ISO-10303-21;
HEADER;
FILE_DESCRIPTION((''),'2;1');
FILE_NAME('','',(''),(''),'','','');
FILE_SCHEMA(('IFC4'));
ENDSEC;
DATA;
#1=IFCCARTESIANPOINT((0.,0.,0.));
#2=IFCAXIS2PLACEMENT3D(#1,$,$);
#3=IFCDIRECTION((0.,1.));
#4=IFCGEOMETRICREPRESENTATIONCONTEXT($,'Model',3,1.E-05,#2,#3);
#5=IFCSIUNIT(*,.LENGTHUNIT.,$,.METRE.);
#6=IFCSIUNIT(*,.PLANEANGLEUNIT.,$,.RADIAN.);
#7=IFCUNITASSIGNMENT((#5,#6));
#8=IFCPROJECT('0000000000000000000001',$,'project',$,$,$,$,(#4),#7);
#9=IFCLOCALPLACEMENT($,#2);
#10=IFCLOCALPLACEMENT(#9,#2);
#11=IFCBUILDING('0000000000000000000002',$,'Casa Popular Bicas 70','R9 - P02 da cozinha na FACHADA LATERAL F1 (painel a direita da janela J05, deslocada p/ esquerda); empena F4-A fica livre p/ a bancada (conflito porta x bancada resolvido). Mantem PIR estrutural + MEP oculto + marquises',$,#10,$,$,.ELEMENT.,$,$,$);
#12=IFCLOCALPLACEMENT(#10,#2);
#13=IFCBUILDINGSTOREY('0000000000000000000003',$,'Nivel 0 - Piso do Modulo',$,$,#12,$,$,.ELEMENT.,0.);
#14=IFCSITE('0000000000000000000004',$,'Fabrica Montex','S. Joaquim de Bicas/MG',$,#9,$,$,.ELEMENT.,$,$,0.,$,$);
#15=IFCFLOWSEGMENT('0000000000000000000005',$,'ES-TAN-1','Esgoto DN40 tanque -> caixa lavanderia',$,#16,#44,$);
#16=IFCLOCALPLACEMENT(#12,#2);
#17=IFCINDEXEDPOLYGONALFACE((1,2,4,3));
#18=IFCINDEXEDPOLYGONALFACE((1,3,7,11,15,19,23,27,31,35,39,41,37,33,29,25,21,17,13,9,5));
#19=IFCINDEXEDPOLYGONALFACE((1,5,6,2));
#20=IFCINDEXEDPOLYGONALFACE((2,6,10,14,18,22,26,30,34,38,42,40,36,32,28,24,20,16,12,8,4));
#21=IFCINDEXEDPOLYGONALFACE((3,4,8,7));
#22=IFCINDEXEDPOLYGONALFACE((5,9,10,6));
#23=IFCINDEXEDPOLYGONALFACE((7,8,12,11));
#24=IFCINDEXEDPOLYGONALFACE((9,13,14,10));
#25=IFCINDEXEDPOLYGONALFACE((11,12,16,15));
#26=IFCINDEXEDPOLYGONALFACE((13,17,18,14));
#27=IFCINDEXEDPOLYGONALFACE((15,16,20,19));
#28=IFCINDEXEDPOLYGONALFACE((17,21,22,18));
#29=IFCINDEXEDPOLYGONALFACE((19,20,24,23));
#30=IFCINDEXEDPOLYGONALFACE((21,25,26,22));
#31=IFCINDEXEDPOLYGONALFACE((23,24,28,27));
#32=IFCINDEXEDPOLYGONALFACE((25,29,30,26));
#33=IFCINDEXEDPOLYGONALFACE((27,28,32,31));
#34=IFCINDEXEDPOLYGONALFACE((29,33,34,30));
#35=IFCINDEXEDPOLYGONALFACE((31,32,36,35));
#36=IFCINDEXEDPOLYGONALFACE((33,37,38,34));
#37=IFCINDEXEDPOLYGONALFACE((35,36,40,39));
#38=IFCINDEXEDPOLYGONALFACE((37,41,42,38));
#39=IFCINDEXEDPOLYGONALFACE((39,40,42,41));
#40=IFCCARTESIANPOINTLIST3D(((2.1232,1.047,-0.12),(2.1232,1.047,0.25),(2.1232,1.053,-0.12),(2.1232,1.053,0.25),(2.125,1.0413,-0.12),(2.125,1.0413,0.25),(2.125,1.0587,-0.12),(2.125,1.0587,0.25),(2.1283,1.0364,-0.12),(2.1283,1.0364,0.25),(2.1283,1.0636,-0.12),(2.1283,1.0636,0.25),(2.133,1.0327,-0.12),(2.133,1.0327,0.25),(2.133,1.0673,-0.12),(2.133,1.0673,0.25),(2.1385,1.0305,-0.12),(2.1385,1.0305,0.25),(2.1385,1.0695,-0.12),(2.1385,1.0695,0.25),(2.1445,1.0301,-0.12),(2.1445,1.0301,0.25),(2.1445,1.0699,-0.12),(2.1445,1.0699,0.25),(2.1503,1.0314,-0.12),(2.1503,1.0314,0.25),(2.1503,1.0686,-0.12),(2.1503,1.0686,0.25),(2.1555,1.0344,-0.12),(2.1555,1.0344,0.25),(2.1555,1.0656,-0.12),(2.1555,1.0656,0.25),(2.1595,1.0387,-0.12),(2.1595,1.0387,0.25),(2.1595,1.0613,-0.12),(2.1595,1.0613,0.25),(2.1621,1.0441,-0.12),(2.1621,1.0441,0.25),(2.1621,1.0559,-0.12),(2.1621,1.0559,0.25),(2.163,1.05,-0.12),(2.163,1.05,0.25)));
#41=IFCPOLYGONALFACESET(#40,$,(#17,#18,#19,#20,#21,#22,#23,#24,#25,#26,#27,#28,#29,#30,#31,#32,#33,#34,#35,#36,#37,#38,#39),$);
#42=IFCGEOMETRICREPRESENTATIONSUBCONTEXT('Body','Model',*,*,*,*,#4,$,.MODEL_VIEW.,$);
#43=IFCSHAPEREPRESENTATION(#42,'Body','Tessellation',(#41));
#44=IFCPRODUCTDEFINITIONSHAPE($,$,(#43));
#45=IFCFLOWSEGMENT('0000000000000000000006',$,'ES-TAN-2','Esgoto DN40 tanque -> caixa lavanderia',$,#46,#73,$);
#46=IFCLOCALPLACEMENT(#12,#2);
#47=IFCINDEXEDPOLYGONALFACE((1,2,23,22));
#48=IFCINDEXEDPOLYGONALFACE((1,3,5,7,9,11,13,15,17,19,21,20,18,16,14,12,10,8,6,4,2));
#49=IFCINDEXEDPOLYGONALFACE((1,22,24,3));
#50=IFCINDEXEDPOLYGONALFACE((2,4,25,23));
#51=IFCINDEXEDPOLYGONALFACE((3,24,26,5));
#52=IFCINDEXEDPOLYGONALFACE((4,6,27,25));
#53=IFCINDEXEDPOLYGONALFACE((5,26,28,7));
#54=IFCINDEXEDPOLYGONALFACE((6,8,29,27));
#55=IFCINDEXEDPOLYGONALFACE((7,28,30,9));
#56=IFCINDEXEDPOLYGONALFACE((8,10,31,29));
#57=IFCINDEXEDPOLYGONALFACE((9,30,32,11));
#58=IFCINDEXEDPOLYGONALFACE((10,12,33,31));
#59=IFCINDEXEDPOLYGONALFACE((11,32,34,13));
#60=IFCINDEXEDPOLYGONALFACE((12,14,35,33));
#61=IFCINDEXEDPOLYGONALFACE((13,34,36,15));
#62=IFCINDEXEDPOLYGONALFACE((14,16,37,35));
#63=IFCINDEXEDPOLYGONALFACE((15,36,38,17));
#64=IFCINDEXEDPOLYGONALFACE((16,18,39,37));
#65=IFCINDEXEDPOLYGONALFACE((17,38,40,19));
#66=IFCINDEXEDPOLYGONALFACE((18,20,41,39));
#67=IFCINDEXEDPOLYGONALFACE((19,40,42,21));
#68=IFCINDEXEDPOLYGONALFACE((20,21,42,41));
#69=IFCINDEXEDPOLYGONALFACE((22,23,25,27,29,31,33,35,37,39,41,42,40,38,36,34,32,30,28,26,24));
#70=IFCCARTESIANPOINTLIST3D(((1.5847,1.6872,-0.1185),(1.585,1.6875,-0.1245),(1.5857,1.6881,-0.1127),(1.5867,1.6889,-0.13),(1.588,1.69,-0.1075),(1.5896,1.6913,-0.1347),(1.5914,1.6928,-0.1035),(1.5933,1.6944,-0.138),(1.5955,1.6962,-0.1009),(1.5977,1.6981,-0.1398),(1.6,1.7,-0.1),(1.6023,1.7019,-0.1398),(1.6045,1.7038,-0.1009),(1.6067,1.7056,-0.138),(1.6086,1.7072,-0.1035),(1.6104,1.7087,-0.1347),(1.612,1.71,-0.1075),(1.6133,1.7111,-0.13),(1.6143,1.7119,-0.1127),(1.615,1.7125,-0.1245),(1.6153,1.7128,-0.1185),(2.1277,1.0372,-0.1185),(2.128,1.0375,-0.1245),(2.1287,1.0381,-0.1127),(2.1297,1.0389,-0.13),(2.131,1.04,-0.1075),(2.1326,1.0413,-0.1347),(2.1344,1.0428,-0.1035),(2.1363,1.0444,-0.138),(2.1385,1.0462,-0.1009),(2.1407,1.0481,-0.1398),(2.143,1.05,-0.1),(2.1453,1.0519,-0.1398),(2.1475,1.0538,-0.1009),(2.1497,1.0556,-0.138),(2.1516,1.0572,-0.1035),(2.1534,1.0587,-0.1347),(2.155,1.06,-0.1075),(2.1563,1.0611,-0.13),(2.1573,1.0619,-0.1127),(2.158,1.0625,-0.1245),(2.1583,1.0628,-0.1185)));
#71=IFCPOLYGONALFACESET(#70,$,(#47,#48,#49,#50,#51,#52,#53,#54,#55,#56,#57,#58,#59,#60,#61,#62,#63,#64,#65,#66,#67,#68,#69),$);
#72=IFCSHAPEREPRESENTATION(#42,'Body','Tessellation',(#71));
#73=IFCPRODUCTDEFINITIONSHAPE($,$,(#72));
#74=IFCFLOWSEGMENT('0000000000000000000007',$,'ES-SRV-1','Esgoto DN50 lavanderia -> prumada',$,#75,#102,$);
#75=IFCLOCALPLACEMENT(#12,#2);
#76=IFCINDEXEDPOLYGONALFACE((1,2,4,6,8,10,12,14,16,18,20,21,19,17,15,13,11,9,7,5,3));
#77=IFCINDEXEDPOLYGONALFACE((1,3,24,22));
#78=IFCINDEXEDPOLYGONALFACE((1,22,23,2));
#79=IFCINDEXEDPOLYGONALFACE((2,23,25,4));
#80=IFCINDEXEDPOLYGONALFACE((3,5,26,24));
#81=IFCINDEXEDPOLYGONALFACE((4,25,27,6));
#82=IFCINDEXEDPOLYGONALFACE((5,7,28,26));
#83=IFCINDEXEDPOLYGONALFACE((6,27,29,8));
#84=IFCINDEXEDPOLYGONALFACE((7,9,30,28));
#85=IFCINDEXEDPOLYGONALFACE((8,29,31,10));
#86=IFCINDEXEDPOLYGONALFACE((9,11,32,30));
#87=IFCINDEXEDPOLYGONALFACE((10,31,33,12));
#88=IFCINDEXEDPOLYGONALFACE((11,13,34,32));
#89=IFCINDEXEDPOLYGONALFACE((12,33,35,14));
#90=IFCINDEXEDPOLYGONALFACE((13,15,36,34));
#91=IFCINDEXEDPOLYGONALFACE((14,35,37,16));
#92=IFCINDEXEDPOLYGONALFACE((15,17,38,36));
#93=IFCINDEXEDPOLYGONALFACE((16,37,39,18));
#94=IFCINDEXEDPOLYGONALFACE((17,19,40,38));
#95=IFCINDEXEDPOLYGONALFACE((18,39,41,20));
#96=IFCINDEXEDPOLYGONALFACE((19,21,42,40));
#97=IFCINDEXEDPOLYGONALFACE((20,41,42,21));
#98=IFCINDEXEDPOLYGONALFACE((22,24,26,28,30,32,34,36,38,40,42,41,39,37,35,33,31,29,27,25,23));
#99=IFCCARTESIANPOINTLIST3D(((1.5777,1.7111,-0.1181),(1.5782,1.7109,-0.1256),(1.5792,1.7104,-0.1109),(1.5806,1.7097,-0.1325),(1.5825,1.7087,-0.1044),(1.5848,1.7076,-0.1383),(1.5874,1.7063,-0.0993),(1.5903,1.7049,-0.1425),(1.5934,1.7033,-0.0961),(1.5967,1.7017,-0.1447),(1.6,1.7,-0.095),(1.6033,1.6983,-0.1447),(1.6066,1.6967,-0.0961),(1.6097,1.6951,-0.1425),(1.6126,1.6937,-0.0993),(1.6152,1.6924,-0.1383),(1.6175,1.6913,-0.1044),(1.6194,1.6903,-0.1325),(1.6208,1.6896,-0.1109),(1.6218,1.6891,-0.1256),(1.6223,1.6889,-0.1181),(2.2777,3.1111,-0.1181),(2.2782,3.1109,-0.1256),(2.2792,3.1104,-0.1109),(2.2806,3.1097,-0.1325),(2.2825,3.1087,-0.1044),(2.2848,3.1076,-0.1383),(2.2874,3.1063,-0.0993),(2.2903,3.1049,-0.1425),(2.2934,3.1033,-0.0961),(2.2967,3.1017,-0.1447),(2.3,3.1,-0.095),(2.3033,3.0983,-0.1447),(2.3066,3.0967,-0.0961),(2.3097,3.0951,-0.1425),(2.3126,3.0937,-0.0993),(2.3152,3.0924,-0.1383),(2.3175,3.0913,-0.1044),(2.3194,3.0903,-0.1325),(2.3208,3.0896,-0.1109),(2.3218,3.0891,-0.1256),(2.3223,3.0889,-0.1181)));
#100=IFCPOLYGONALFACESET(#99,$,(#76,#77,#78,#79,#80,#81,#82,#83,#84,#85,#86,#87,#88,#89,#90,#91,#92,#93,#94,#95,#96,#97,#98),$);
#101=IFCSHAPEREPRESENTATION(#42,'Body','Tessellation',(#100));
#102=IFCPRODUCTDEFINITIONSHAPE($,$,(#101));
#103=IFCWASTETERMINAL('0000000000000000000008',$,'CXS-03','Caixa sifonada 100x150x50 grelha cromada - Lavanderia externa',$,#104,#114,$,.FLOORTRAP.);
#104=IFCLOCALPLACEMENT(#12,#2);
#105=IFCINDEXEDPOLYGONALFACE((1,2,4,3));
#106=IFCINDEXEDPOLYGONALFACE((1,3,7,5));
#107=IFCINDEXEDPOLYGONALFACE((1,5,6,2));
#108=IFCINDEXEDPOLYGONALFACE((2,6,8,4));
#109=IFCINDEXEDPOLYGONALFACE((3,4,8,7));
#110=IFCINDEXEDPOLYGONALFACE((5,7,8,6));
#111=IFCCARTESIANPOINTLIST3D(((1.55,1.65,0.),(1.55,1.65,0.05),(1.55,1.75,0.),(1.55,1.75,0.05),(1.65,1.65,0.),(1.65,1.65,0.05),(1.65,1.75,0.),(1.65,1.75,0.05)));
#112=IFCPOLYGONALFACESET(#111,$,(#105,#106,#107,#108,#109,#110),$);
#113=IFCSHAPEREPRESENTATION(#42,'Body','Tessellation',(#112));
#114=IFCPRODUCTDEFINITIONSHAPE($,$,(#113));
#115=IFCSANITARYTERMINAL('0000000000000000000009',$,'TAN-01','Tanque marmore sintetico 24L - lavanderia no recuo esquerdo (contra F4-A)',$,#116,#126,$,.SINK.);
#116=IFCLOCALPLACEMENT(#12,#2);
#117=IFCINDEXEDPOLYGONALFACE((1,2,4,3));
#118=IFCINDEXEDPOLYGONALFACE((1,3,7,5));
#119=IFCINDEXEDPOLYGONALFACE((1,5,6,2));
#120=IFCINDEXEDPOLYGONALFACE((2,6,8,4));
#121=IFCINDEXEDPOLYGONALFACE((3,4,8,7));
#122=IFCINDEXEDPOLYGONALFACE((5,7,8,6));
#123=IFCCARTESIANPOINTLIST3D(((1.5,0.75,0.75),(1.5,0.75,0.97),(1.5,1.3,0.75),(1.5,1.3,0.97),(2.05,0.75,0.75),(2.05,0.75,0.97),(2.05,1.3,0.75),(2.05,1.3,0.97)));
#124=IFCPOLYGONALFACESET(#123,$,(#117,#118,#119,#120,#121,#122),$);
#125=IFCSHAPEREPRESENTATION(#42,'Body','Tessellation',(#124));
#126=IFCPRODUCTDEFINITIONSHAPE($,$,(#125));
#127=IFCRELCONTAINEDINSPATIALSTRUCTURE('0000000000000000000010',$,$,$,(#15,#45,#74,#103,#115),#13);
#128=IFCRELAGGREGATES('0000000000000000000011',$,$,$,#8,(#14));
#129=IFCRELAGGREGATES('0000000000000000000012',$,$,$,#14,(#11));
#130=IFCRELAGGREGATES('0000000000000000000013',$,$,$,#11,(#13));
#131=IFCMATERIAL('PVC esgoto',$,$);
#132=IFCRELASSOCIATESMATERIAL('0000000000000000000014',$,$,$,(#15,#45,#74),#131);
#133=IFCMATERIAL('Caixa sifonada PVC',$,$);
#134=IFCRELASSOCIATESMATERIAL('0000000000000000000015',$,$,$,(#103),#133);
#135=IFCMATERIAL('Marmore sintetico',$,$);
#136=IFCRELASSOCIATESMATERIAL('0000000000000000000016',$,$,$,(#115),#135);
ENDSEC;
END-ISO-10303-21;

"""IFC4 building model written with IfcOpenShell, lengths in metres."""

from ifc_helpers import new_model, si_unit, direction, frame, frame_2d, origin, origin_2d, place, context, subcontext, project, spatial, rectangle, circle, extrude, material, element, save


model = new_model("IFC4")

# Units and contexts
model_context = context("Model", 3, precision=1e-05, world=origin(), true_north=direction((0.0, 1.0)))
body_context = subcontext(model_context, "Body", "Model", "MODEL_VIEW")
ifc_project = project(units=[si_unit("LENGTHUNIT", "METRE"), si_unit("PLANEANGLEUNIT", "RADIAN")], contexts=[model_context])

# Site, building, storey
site_placement = place(None, origin())
site = spatial("IfcSite", under=ifc_project, at=site_placement, Name="Fabrica Montex", Description="S. Joaquim de Bicas/MG", CompositionType="ELEMENT", RefElevation=0.0)
building_placement = place(site_placement, origin())
building = spatial("IfcBuilding", under=site, at=building_placement, Name="Casa Popular Bicas 70", Description="R9 - P02 da cozinha na FACHADA LATERAL F1 (painel a direita da janela J05, deslocada p/ esquerda); empena F4-A fica livre p/ a bancada (conflito porta x bancada resolvido). Mantem PIR estrutural + MEP oculto + marquises", CompositionType="ELEMENT")
storey_placement = place(building_placement, origin())
storey = spatial("IfcBuildingStorey", under=building, at=storey_placement, Name="Nivel 0 - Piso do Modulo", CompositionType="ELEMENT", Elevation=0.0)

# Flow segments
ifc_material_1 = material(Name="PVC esgoto")
flow_segment_1_placement = place(storey_placement, frame((2.143, 1.05, 0.25), z_axis=(0.0, 0.0, -1.0), x_axis=(1.0, 0.0, 0.0)))
element("IfcFlowSegment", 1, at=flow_segment_1_placement, inside=storey, material=ifc_material_1, Name="ES-TAN-1", Description="Esgoto DN40 tanque -> caixa lavanderia", context=body_context, shape_type="SweptSolid", body=[
    extrude(circle(Radius=0.02, at=origin_2d()), origin(), (0.0, 0.0, 1.0), 0.37),
])
flow_segment_2_placement = place(storey_placement, frame((2.143, 1.05, -0.12), z_axis=(-0.641113, 0.767446, 0.0), x_axis=(0.0, 0.0, 1.0)))
element("IfcFlowSegment", 2, at=flow_segment_2_placement, inside=storey, material=ifc_material_1, Name="ES-TAN-2", Description="Esgoto DN40 tanque -> caixa lavanderia", context=body_context, shape_type="SweptSolid", body=[
    extrude(circle(Radius=0.02, at=origin_2d()), origin(), (0.0, 0.0, 1.0), 0.847),
])
flow_segment_3_placement = place(storey_placement, frame((1.6, 1.7, -0.12), z_axis=(0.447214, 0.894427, 0.0), x_axis=(0.0, 0.0, 1.0)))
element("IfcFlowSegment", 3, at=flow_segment_3_placement, inside=storey, material=ifc_material_1, Name="ES-SRV-1", Description="Esgoto DN50 lavanderia -> prumada", context=body_context, shape_type="SweptSolid", body=[
    extrude(circle(Radius=0.025, at=origin_2d()), origin(), (0.0, 0.0, 1.0), 1.5652),
])

# Waste terminal
ifc_material_2 = material(Name="Caixa sifonada PVC")
waste_terminal_placement = place(storey_placement, frame((1.55, 1.65, 0.0)))
element("IfcWasteTerminal", 4, at=waste_terminal_placement, inside=storey, material=ifc_material_2, Name="CXS-03", Description="Caixa sifonada 100x150x50 grelha cromada - Lavanderia externa", PredefinedType="FLOORTRAP", context=body_context, shape_type="SweptSolid", body=[
    extrude(rectangle(XDim=0.1, YDim=0.1, at=frame_2d((0.05, 0.05))), origin(), (0.0, 0.0, 1.0), 0.05),
])

# Sanitary terminal
ifc_material_3 = material(Name="Marmore sintetico")
sanitary_terminal_placement = place(storey_placement, frame((1.5, 0.75, 0.75)))
element("IfcSanitaryTerminal", 5, at=sanitary_terminal_placement, inside=storey, material=ifc_material_3, Name="TAN-01", Description="Tanque marmore sintetico 24L - lavanderia no recuo esquerdo (contra F4-A)", PredefinedType="SINK", context=body_context, shape_type="SweptSolid", body=[
    extrude(rectangle(XDim=0.55, YDim=0.55, at=frame_2d((0.275, 0.275))), origin(), (0.0, 0.0, 1.0), 0.22),
])

save(model, "model.ifc")
